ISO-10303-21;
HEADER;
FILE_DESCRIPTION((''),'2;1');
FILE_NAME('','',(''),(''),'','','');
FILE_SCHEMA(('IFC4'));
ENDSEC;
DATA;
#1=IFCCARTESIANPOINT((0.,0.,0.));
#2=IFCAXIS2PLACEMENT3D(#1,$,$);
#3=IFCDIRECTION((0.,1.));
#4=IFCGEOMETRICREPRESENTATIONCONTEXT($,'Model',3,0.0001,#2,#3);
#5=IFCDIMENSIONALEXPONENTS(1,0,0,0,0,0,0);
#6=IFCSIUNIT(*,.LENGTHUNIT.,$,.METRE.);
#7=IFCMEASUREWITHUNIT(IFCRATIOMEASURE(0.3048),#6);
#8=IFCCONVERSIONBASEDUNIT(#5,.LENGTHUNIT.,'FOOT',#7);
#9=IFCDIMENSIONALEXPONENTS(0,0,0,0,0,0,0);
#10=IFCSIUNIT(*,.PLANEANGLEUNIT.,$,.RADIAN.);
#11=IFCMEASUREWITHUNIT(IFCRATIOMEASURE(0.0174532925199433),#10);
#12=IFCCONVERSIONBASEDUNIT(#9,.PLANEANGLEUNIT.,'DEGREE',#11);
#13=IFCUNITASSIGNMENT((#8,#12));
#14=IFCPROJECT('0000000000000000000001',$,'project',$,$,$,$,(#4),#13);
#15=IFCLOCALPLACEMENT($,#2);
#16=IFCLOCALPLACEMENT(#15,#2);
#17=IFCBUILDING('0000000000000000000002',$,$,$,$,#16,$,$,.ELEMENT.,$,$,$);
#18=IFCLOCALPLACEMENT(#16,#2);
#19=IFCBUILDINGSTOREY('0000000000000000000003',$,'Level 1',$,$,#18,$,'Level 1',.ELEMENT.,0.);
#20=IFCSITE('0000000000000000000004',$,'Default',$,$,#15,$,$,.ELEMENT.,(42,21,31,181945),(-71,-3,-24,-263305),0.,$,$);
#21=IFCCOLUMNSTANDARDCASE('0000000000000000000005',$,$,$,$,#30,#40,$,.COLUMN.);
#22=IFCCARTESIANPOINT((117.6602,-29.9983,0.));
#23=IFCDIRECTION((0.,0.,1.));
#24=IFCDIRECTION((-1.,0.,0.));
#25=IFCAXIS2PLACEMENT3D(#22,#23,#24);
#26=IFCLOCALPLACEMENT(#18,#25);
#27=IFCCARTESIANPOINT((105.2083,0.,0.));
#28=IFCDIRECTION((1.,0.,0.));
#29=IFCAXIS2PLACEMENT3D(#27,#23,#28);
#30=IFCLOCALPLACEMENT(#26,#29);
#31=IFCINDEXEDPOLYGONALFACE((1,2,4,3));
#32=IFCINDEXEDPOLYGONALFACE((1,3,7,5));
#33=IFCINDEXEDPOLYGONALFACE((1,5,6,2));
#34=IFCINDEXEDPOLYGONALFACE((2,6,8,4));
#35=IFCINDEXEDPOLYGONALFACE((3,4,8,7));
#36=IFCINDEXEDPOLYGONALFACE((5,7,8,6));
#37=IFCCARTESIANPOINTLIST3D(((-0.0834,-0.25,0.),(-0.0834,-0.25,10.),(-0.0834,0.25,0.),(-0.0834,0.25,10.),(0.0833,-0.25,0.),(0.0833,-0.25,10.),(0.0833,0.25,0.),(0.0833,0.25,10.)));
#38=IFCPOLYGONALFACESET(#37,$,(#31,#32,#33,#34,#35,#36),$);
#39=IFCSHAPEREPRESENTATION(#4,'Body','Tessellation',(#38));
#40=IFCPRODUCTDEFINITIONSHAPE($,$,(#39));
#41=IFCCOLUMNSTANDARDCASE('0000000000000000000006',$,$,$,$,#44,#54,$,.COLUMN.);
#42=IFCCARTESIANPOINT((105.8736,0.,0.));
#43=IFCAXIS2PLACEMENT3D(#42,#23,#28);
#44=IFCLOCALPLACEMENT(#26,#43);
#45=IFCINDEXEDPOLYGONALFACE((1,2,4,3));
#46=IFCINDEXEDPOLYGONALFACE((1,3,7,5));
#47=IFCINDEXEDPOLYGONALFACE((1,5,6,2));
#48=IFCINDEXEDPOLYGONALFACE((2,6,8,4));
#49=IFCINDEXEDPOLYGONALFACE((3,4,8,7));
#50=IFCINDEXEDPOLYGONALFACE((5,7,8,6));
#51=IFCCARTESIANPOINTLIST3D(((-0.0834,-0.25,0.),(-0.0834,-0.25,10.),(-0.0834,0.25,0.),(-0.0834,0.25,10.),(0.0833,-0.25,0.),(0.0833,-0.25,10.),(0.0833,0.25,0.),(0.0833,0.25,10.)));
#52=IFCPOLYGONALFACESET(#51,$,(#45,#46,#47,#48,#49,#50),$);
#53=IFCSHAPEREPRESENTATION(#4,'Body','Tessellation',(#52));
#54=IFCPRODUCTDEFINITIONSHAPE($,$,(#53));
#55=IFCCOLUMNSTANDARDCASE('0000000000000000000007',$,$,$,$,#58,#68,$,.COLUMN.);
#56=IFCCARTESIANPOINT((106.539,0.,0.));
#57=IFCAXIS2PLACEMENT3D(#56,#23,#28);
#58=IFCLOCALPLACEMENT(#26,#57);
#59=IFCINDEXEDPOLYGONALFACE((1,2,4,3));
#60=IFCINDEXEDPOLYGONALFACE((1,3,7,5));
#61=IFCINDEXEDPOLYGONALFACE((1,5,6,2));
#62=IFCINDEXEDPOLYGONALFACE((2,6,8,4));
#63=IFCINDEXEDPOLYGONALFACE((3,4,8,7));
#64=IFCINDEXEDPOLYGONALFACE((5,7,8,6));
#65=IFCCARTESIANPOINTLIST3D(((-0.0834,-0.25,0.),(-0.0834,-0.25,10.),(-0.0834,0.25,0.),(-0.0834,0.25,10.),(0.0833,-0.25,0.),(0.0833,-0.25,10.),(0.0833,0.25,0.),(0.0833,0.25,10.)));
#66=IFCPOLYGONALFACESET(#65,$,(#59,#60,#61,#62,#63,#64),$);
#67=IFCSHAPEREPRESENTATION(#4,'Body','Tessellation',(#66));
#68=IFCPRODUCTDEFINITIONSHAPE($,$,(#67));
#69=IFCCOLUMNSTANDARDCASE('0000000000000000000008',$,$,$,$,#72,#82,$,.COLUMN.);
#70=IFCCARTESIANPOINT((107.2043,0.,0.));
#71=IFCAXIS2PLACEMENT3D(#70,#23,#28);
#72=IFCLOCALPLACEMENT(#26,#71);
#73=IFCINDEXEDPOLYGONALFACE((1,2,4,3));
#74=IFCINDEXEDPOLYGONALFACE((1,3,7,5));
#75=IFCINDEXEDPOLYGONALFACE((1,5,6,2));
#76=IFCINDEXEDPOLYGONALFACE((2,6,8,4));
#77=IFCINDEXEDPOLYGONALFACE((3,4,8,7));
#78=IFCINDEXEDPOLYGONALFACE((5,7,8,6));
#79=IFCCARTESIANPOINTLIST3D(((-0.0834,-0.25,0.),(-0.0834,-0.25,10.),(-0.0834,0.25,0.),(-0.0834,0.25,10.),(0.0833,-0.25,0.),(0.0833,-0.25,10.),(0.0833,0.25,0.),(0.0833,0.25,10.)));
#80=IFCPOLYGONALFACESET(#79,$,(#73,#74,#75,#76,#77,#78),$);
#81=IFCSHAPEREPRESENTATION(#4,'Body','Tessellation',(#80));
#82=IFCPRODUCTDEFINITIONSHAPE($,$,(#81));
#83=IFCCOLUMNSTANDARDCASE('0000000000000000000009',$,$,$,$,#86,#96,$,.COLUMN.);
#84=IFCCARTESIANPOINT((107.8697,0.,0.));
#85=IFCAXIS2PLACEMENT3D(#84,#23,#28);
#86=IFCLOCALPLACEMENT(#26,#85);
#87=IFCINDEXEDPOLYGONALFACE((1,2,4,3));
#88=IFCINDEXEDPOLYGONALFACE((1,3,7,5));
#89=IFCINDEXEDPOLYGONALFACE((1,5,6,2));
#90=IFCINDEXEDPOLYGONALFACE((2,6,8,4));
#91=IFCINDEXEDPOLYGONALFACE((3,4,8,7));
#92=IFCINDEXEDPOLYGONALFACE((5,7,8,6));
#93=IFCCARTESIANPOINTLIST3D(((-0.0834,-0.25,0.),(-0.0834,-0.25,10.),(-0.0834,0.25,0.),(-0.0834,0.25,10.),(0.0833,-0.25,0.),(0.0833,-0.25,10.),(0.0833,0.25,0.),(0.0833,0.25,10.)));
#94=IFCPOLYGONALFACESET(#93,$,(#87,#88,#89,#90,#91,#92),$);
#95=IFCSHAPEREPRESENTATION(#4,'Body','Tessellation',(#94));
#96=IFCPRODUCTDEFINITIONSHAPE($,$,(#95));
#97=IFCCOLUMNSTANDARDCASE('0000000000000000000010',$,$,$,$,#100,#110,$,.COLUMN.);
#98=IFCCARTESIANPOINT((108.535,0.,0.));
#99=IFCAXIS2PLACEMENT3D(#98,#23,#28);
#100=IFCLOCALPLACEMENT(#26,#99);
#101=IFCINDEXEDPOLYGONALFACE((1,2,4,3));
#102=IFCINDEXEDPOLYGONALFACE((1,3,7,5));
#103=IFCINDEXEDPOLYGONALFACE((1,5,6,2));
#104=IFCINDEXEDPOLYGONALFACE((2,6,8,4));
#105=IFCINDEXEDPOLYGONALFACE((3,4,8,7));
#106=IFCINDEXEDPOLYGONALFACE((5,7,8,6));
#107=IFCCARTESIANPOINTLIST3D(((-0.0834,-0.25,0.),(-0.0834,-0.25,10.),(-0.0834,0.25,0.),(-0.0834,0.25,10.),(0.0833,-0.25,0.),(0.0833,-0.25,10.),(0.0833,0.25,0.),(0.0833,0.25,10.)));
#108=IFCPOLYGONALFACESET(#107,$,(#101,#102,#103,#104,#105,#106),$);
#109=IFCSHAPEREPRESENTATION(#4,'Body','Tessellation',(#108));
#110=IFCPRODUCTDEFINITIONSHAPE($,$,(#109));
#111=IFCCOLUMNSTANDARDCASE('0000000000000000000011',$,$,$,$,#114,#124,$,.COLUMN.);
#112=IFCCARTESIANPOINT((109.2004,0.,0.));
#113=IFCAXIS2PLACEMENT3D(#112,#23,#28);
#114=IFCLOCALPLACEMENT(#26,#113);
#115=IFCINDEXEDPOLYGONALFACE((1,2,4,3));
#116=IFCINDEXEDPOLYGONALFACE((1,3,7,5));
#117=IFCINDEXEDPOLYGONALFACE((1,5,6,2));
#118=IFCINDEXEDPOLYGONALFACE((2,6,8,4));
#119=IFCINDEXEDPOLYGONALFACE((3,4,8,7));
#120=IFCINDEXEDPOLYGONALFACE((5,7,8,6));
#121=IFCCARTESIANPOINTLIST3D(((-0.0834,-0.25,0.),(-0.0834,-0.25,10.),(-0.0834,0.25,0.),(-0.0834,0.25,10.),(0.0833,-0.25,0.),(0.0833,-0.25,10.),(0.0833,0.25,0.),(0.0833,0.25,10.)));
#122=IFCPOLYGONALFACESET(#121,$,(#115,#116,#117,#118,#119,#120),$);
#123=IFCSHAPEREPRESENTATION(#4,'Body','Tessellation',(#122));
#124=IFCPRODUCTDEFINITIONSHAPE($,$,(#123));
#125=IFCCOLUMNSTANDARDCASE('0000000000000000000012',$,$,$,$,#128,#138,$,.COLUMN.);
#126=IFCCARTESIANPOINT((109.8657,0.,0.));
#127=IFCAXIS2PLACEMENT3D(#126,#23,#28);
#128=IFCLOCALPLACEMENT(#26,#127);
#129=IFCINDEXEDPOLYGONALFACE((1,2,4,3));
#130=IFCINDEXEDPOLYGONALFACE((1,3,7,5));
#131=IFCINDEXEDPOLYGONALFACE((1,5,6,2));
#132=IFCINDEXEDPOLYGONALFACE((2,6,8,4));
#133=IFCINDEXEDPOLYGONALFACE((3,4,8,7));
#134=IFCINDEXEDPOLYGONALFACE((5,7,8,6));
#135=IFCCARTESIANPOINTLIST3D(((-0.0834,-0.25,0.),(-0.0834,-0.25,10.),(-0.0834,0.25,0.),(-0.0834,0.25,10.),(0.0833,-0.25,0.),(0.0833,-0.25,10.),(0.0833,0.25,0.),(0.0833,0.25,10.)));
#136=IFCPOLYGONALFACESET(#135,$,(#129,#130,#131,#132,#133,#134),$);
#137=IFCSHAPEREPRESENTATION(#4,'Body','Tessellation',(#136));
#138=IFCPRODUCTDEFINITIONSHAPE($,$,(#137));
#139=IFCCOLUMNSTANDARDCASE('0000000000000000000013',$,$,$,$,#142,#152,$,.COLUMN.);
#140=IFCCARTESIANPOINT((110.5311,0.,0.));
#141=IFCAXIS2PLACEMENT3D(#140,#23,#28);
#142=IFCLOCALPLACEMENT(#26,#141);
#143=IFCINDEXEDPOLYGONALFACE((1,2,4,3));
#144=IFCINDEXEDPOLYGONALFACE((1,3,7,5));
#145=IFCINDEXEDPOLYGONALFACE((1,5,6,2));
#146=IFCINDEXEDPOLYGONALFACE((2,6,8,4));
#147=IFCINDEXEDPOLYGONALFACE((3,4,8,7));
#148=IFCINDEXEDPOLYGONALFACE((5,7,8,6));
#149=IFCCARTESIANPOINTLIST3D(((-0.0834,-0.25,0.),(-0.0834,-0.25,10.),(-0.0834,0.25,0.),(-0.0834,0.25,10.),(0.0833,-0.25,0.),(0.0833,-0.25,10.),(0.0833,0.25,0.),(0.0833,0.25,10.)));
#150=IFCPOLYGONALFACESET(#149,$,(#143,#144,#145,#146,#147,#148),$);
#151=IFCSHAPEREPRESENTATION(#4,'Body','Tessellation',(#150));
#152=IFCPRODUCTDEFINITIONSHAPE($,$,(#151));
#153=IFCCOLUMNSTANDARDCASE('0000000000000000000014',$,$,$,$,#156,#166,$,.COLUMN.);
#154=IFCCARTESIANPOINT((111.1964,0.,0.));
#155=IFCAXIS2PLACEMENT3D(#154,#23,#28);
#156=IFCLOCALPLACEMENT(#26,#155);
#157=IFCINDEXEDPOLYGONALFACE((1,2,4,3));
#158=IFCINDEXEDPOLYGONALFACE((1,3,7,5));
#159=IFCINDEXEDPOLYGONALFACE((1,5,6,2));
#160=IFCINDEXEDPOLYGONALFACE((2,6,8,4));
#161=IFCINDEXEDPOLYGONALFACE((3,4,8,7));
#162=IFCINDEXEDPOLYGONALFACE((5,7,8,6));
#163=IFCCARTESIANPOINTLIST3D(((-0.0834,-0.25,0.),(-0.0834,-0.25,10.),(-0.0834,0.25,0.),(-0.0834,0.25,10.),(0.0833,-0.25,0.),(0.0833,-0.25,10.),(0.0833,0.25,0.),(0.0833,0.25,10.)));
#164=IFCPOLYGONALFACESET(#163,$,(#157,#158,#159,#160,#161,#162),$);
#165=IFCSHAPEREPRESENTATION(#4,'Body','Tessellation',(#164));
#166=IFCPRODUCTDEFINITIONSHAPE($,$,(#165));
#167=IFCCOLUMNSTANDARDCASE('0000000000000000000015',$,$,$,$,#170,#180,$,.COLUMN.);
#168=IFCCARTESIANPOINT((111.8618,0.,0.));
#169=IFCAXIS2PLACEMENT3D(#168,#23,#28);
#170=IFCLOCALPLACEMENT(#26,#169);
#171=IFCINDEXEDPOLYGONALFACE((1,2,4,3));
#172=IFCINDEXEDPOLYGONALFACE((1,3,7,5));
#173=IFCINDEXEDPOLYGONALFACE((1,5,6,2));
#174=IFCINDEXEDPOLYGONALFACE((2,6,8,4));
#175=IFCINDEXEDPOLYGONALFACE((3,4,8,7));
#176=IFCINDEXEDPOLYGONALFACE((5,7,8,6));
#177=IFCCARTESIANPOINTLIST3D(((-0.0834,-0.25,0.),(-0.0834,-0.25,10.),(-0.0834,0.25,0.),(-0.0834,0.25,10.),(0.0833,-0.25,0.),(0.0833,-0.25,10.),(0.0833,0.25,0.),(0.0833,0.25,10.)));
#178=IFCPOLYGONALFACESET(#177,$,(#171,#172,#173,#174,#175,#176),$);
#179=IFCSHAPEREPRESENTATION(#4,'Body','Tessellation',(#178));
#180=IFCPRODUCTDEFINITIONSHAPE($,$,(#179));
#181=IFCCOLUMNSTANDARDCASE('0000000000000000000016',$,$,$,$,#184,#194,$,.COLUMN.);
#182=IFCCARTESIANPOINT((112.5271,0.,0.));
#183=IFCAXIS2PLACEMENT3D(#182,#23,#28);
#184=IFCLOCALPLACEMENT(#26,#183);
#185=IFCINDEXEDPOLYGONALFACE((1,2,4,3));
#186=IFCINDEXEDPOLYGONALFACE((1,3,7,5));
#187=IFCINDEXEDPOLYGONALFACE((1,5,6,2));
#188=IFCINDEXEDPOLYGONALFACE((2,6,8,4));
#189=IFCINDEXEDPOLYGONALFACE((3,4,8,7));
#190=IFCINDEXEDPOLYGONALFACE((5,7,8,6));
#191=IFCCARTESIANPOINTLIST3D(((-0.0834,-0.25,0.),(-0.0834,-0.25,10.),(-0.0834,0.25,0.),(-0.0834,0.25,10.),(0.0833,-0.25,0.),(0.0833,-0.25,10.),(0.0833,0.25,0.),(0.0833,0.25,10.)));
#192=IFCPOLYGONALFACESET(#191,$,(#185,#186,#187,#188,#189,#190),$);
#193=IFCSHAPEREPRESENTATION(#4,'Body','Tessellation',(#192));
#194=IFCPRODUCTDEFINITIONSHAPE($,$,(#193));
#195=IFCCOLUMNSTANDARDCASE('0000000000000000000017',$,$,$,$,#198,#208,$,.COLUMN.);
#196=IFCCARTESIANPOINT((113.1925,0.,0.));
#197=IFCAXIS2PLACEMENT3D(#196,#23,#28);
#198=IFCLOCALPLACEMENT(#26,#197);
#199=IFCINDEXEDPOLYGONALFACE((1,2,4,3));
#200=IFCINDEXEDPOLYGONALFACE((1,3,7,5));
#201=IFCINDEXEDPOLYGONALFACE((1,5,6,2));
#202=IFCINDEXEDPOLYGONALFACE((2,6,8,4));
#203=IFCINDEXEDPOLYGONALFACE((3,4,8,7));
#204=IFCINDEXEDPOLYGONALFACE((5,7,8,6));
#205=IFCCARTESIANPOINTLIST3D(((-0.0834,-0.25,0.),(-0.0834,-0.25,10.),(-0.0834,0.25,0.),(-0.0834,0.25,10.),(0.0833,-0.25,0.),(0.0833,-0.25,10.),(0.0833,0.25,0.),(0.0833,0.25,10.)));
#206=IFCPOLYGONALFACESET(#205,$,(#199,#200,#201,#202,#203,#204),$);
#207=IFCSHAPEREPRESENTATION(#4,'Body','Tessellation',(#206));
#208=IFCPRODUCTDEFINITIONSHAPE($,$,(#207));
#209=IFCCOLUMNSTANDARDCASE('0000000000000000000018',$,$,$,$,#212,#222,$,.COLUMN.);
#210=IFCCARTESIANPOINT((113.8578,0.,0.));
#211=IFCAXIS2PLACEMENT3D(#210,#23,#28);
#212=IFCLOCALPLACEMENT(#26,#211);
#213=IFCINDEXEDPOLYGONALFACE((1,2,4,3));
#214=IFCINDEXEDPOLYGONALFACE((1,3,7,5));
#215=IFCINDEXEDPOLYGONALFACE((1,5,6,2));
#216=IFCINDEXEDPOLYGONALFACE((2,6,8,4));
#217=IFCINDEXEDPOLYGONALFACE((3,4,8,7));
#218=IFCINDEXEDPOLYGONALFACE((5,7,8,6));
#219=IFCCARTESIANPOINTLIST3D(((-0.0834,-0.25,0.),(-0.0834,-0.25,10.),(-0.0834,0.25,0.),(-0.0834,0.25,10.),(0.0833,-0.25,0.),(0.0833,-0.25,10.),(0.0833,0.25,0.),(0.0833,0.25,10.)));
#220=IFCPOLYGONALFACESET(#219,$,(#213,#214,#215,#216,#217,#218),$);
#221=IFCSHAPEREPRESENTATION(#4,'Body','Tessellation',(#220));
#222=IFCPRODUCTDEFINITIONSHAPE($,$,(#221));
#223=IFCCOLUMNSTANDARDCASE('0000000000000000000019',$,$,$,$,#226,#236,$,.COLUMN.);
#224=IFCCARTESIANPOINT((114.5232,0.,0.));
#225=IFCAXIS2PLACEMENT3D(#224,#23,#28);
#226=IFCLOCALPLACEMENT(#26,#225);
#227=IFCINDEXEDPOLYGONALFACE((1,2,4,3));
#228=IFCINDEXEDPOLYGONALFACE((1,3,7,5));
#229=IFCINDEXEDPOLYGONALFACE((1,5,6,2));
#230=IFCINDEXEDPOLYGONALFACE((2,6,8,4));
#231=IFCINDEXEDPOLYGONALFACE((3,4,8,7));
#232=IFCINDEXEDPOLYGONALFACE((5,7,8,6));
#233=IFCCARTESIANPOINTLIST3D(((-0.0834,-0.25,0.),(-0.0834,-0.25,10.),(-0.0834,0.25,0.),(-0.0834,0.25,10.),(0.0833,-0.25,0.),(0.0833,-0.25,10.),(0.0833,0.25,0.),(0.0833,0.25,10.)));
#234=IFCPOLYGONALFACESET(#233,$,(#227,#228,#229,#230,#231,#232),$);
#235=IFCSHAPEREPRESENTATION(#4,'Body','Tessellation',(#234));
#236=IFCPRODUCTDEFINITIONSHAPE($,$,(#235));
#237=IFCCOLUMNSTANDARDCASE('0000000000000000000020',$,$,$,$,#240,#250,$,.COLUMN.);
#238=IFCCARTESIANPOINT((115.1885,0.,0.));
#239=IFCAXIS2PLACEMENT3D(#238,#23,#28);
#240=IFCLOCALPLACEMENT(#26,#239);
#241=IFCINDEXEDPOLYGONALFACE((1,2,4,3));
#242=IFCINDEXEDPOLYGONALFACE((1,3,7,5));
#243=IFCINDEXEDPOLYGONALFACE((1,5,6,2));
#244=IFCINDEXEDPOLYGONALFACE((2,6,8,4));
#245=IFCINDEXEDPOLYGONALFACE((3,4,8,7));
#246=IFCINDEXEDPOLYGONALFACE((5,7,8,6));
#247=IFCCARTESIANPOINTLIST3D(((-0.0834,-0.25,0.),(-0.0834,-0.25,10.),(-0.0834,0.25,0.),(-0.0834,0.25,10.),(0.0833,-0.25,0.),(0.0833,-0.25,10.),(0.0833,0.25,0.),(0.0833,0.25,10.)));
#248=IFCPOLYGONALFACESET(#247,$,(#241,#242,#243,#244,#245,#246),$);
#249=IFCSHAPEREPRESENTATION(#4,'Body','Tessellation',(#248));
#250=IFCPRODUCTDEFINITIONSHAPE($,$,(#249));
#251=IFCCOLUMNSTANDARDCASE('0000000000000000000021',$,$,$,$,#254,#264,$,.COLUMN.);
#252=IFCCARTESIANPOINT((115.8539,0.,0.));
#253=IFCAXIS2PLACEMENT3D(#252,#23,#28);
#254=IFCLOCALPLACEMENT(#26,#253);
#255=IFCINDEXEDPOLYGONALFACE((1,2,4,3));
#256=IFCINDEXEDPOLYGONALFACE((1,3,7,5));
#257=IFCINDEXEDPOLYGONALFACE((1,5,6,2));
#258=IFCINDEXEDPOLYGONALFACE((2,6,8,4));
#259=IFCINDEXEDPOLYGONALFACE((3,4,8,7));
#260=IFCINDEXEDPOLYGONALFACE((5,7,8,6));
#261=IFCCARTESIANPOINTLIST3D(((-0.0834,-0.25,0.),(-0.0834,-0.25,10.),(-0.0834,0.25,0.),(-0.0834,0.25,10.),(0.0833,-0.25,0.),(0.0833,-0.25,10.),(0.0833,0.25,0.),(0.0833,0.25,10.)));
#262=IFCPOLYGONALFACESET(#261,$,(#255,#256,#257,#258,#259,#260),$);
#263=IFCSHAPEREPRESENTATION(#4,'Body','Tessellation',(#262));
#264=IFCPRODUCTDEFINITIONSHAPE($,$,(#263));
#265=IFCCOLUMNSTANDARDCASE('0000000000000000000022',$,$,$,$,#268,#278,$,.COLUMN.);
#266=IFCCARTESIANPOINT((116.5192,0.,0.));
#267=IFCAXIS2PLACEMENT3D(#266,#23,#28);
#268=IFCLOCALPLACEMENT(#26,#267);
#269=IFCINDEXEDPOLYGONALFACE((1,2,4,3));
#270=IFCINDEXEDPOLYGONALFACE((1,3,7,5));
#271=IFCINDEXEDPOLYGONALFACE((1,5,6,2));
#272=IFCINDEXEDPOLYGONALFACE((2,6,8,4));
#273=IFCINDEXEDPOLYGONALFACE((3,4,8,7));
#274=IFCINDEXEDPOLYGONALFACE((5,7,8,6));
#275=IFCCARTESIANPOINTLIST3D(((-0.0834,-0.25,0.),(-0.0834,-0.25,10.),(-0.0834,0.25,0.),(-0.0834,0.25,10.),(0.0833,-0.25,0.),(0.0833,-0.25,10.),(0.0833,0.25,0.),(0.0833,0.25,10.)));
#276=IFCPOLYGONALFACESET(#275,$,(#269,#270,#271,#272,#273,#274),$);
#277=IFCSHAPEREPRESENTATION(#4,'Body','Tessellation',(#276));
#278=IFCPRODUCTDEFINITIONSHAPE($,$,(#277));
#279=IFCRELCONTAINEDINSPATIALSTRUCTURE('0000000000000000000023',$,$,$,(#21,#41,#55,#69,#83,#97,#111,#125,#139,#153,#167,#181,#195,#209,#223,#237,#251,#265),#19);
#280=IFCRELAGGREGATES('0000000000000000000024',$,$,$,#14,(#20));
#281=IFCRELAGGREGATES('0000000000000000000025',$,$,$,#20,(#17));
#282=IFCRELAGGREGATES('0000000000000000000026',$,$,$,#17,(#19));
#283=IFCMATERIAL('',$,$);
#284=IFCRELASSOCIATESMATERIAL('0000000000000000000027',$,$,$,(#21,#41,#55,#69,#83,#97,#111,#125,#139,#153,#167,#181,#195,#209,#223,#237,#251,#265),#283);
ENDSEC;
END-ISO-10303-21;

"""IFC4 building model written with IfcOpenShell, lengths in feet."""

from ifc_helpers import new_model, entity, si_unit, converted_unit, direction, frame, origin, place, context, project, spatial, rectangle, extrude, material, element, save


model = new_model("IFC4")

# Units and contexts
model_context = context("Model", 3, precision=0.0001, world=origin(), true_north=direction((0.0, 1.0)))
ifc_project = project(units=[converted_unit("LENGTHUNIT", "FOOT", entity("IfcRatioMeasure", 0.3048), si_unit("LENGTHUNIT", "METRE"), dimensions=[1, 0, 0, 0, 0, 0, 0]), converted_unit("PLANEANGLEUNIT", "DEGREE", entity("IfcRatioMeasure", 0.0174532925199433), si_unit("PLANEANGLEUNIT", "RADIAN"), dimensions=[0, 0, 0, 0, 0, 0, 0])], contexts=[model_context])

# Site, building, storey
site_placement = place(None, origin())
site = spatial("IfcSite", under=ifc_project, at=site_placement, Name="Default", CompositionType="ELEMENT", RefLatitude=(42, 21, 31, 181945), RefLongitude=(-71, -3, -24, -263305), RefElevation=0.0)
building_placement = place(site_placement, origin())
building = spatial("IfcBuilding", under=site, at=building_placement, CompositionType="ELEMENT")
storey_placement = place(building_placement, origin())
storey = spatial("IfcBuildingStorey", under=building, at=storey_placement, Name="Level 1", LongName="Level 1", CompositionType="ELEMENT", Elevation=0.0)

# Columns
ifc_material = material(Name="")
placement = place(storey_placement, frame((117.6602, -29.9983, 0.0), z_axis=(0.0, 0.0, 1.0), x_axis=(-1.0, 0.0, 0.0)))
for number, where, z_axis, x_axis in (
    (1, (105.2083, 0.0, 0.0), (0.0, 0.0, 1.0), (1.0, 0.0, 0.0)),
    (2, (105.8736, 0.0, 0.0), (0.0, 0.0, 1.0), (1.0, 0.0, 0.0)),
    (3, (106.539, 0.0, 0.0), (0.0, 0.0, 1.0), (1.0, 0.0, 0.0)),
    (4, (107.2043, 0.0, 0.0), (0.0, 0.0, 1.0), (1.0, 0.0, 0.0)),
    (5, (107.8697, 0.0, 0.0), (0.0, 0.0, 1.0), (1.0, 0.0, 0.0)),
    (6, (108.535, 0.0, 0.0), (0.0, 0.0, 1.0), (1.0, 0.0, 0.0)),
    (7, (109.2004, 0.0, 0.0), (0.0, 0.0, 1.0), (1.0, 0.0, 0.0)),
    (8, (109.8657, 0.0, 0.0), (0.0, 0.0, 1.0), (1.0, 0.0, 0.0)),
    (9, (110.5311, 0.0, 0.0), (0.0, 0.0, 1.0), (1.0, 0.0, 0.0)),
    (10, (111.1964, 0.0, 0.0), (0.0, 0.0, 1.0), (1.0, 0.0, 0.0)),
    (11, (111.8618, 0.0, 0.0), (0.0, 0.0, 1.0), (1.0, 0.0, 0.0)),
    (12, (112.5271, 0.0, 0.0), (0.0, 0.0, 1.0), (1.0, 0.0, 0.0)),
    (13, (113.1925, 0.0, 0.0), (0.0, 0.0, 1.0), (1.0, 0.0, 0.0)),
    (14, (113.8578, 0.0, 0.0), (0.0, 0.0, 1.0), (1.0, 0.0, 0.0)),
    (15, (114.5232, 0.0, 0.0), (0.0, 0.0, 1.0), (1.0, 0.0, 0.0)),
    (16, (115.1885, 0.0, 0.0), (0.0, 0.0, 1.0), (1.0, 0.0, 0.0)),
    (17, (115.8539, 0.0, 0.0), (0.0, 0.0, 1.0), (1.0, 0.0, 0.0)),
    (18, (116.5192, 0.0, 0.0), (0.0, 0.0, 1.0), (1.0, 0.0, 0.0)),
):
    element("IfcColumnStandardCase", number, at=place(placement, frame(where, z_axis=z_axis, x_axis=x_axis)), inside=storey, material=ifc_material, PredefinedType="COLUMN", context=model_context, shape_type="SweptSolid", body=[
        extrude(rectangle(XDim=0.1667, YDim=0.5), origin(), (0.0, 0.0, 1.0), 10.0),
    ])

save(model, "model.ifc")
